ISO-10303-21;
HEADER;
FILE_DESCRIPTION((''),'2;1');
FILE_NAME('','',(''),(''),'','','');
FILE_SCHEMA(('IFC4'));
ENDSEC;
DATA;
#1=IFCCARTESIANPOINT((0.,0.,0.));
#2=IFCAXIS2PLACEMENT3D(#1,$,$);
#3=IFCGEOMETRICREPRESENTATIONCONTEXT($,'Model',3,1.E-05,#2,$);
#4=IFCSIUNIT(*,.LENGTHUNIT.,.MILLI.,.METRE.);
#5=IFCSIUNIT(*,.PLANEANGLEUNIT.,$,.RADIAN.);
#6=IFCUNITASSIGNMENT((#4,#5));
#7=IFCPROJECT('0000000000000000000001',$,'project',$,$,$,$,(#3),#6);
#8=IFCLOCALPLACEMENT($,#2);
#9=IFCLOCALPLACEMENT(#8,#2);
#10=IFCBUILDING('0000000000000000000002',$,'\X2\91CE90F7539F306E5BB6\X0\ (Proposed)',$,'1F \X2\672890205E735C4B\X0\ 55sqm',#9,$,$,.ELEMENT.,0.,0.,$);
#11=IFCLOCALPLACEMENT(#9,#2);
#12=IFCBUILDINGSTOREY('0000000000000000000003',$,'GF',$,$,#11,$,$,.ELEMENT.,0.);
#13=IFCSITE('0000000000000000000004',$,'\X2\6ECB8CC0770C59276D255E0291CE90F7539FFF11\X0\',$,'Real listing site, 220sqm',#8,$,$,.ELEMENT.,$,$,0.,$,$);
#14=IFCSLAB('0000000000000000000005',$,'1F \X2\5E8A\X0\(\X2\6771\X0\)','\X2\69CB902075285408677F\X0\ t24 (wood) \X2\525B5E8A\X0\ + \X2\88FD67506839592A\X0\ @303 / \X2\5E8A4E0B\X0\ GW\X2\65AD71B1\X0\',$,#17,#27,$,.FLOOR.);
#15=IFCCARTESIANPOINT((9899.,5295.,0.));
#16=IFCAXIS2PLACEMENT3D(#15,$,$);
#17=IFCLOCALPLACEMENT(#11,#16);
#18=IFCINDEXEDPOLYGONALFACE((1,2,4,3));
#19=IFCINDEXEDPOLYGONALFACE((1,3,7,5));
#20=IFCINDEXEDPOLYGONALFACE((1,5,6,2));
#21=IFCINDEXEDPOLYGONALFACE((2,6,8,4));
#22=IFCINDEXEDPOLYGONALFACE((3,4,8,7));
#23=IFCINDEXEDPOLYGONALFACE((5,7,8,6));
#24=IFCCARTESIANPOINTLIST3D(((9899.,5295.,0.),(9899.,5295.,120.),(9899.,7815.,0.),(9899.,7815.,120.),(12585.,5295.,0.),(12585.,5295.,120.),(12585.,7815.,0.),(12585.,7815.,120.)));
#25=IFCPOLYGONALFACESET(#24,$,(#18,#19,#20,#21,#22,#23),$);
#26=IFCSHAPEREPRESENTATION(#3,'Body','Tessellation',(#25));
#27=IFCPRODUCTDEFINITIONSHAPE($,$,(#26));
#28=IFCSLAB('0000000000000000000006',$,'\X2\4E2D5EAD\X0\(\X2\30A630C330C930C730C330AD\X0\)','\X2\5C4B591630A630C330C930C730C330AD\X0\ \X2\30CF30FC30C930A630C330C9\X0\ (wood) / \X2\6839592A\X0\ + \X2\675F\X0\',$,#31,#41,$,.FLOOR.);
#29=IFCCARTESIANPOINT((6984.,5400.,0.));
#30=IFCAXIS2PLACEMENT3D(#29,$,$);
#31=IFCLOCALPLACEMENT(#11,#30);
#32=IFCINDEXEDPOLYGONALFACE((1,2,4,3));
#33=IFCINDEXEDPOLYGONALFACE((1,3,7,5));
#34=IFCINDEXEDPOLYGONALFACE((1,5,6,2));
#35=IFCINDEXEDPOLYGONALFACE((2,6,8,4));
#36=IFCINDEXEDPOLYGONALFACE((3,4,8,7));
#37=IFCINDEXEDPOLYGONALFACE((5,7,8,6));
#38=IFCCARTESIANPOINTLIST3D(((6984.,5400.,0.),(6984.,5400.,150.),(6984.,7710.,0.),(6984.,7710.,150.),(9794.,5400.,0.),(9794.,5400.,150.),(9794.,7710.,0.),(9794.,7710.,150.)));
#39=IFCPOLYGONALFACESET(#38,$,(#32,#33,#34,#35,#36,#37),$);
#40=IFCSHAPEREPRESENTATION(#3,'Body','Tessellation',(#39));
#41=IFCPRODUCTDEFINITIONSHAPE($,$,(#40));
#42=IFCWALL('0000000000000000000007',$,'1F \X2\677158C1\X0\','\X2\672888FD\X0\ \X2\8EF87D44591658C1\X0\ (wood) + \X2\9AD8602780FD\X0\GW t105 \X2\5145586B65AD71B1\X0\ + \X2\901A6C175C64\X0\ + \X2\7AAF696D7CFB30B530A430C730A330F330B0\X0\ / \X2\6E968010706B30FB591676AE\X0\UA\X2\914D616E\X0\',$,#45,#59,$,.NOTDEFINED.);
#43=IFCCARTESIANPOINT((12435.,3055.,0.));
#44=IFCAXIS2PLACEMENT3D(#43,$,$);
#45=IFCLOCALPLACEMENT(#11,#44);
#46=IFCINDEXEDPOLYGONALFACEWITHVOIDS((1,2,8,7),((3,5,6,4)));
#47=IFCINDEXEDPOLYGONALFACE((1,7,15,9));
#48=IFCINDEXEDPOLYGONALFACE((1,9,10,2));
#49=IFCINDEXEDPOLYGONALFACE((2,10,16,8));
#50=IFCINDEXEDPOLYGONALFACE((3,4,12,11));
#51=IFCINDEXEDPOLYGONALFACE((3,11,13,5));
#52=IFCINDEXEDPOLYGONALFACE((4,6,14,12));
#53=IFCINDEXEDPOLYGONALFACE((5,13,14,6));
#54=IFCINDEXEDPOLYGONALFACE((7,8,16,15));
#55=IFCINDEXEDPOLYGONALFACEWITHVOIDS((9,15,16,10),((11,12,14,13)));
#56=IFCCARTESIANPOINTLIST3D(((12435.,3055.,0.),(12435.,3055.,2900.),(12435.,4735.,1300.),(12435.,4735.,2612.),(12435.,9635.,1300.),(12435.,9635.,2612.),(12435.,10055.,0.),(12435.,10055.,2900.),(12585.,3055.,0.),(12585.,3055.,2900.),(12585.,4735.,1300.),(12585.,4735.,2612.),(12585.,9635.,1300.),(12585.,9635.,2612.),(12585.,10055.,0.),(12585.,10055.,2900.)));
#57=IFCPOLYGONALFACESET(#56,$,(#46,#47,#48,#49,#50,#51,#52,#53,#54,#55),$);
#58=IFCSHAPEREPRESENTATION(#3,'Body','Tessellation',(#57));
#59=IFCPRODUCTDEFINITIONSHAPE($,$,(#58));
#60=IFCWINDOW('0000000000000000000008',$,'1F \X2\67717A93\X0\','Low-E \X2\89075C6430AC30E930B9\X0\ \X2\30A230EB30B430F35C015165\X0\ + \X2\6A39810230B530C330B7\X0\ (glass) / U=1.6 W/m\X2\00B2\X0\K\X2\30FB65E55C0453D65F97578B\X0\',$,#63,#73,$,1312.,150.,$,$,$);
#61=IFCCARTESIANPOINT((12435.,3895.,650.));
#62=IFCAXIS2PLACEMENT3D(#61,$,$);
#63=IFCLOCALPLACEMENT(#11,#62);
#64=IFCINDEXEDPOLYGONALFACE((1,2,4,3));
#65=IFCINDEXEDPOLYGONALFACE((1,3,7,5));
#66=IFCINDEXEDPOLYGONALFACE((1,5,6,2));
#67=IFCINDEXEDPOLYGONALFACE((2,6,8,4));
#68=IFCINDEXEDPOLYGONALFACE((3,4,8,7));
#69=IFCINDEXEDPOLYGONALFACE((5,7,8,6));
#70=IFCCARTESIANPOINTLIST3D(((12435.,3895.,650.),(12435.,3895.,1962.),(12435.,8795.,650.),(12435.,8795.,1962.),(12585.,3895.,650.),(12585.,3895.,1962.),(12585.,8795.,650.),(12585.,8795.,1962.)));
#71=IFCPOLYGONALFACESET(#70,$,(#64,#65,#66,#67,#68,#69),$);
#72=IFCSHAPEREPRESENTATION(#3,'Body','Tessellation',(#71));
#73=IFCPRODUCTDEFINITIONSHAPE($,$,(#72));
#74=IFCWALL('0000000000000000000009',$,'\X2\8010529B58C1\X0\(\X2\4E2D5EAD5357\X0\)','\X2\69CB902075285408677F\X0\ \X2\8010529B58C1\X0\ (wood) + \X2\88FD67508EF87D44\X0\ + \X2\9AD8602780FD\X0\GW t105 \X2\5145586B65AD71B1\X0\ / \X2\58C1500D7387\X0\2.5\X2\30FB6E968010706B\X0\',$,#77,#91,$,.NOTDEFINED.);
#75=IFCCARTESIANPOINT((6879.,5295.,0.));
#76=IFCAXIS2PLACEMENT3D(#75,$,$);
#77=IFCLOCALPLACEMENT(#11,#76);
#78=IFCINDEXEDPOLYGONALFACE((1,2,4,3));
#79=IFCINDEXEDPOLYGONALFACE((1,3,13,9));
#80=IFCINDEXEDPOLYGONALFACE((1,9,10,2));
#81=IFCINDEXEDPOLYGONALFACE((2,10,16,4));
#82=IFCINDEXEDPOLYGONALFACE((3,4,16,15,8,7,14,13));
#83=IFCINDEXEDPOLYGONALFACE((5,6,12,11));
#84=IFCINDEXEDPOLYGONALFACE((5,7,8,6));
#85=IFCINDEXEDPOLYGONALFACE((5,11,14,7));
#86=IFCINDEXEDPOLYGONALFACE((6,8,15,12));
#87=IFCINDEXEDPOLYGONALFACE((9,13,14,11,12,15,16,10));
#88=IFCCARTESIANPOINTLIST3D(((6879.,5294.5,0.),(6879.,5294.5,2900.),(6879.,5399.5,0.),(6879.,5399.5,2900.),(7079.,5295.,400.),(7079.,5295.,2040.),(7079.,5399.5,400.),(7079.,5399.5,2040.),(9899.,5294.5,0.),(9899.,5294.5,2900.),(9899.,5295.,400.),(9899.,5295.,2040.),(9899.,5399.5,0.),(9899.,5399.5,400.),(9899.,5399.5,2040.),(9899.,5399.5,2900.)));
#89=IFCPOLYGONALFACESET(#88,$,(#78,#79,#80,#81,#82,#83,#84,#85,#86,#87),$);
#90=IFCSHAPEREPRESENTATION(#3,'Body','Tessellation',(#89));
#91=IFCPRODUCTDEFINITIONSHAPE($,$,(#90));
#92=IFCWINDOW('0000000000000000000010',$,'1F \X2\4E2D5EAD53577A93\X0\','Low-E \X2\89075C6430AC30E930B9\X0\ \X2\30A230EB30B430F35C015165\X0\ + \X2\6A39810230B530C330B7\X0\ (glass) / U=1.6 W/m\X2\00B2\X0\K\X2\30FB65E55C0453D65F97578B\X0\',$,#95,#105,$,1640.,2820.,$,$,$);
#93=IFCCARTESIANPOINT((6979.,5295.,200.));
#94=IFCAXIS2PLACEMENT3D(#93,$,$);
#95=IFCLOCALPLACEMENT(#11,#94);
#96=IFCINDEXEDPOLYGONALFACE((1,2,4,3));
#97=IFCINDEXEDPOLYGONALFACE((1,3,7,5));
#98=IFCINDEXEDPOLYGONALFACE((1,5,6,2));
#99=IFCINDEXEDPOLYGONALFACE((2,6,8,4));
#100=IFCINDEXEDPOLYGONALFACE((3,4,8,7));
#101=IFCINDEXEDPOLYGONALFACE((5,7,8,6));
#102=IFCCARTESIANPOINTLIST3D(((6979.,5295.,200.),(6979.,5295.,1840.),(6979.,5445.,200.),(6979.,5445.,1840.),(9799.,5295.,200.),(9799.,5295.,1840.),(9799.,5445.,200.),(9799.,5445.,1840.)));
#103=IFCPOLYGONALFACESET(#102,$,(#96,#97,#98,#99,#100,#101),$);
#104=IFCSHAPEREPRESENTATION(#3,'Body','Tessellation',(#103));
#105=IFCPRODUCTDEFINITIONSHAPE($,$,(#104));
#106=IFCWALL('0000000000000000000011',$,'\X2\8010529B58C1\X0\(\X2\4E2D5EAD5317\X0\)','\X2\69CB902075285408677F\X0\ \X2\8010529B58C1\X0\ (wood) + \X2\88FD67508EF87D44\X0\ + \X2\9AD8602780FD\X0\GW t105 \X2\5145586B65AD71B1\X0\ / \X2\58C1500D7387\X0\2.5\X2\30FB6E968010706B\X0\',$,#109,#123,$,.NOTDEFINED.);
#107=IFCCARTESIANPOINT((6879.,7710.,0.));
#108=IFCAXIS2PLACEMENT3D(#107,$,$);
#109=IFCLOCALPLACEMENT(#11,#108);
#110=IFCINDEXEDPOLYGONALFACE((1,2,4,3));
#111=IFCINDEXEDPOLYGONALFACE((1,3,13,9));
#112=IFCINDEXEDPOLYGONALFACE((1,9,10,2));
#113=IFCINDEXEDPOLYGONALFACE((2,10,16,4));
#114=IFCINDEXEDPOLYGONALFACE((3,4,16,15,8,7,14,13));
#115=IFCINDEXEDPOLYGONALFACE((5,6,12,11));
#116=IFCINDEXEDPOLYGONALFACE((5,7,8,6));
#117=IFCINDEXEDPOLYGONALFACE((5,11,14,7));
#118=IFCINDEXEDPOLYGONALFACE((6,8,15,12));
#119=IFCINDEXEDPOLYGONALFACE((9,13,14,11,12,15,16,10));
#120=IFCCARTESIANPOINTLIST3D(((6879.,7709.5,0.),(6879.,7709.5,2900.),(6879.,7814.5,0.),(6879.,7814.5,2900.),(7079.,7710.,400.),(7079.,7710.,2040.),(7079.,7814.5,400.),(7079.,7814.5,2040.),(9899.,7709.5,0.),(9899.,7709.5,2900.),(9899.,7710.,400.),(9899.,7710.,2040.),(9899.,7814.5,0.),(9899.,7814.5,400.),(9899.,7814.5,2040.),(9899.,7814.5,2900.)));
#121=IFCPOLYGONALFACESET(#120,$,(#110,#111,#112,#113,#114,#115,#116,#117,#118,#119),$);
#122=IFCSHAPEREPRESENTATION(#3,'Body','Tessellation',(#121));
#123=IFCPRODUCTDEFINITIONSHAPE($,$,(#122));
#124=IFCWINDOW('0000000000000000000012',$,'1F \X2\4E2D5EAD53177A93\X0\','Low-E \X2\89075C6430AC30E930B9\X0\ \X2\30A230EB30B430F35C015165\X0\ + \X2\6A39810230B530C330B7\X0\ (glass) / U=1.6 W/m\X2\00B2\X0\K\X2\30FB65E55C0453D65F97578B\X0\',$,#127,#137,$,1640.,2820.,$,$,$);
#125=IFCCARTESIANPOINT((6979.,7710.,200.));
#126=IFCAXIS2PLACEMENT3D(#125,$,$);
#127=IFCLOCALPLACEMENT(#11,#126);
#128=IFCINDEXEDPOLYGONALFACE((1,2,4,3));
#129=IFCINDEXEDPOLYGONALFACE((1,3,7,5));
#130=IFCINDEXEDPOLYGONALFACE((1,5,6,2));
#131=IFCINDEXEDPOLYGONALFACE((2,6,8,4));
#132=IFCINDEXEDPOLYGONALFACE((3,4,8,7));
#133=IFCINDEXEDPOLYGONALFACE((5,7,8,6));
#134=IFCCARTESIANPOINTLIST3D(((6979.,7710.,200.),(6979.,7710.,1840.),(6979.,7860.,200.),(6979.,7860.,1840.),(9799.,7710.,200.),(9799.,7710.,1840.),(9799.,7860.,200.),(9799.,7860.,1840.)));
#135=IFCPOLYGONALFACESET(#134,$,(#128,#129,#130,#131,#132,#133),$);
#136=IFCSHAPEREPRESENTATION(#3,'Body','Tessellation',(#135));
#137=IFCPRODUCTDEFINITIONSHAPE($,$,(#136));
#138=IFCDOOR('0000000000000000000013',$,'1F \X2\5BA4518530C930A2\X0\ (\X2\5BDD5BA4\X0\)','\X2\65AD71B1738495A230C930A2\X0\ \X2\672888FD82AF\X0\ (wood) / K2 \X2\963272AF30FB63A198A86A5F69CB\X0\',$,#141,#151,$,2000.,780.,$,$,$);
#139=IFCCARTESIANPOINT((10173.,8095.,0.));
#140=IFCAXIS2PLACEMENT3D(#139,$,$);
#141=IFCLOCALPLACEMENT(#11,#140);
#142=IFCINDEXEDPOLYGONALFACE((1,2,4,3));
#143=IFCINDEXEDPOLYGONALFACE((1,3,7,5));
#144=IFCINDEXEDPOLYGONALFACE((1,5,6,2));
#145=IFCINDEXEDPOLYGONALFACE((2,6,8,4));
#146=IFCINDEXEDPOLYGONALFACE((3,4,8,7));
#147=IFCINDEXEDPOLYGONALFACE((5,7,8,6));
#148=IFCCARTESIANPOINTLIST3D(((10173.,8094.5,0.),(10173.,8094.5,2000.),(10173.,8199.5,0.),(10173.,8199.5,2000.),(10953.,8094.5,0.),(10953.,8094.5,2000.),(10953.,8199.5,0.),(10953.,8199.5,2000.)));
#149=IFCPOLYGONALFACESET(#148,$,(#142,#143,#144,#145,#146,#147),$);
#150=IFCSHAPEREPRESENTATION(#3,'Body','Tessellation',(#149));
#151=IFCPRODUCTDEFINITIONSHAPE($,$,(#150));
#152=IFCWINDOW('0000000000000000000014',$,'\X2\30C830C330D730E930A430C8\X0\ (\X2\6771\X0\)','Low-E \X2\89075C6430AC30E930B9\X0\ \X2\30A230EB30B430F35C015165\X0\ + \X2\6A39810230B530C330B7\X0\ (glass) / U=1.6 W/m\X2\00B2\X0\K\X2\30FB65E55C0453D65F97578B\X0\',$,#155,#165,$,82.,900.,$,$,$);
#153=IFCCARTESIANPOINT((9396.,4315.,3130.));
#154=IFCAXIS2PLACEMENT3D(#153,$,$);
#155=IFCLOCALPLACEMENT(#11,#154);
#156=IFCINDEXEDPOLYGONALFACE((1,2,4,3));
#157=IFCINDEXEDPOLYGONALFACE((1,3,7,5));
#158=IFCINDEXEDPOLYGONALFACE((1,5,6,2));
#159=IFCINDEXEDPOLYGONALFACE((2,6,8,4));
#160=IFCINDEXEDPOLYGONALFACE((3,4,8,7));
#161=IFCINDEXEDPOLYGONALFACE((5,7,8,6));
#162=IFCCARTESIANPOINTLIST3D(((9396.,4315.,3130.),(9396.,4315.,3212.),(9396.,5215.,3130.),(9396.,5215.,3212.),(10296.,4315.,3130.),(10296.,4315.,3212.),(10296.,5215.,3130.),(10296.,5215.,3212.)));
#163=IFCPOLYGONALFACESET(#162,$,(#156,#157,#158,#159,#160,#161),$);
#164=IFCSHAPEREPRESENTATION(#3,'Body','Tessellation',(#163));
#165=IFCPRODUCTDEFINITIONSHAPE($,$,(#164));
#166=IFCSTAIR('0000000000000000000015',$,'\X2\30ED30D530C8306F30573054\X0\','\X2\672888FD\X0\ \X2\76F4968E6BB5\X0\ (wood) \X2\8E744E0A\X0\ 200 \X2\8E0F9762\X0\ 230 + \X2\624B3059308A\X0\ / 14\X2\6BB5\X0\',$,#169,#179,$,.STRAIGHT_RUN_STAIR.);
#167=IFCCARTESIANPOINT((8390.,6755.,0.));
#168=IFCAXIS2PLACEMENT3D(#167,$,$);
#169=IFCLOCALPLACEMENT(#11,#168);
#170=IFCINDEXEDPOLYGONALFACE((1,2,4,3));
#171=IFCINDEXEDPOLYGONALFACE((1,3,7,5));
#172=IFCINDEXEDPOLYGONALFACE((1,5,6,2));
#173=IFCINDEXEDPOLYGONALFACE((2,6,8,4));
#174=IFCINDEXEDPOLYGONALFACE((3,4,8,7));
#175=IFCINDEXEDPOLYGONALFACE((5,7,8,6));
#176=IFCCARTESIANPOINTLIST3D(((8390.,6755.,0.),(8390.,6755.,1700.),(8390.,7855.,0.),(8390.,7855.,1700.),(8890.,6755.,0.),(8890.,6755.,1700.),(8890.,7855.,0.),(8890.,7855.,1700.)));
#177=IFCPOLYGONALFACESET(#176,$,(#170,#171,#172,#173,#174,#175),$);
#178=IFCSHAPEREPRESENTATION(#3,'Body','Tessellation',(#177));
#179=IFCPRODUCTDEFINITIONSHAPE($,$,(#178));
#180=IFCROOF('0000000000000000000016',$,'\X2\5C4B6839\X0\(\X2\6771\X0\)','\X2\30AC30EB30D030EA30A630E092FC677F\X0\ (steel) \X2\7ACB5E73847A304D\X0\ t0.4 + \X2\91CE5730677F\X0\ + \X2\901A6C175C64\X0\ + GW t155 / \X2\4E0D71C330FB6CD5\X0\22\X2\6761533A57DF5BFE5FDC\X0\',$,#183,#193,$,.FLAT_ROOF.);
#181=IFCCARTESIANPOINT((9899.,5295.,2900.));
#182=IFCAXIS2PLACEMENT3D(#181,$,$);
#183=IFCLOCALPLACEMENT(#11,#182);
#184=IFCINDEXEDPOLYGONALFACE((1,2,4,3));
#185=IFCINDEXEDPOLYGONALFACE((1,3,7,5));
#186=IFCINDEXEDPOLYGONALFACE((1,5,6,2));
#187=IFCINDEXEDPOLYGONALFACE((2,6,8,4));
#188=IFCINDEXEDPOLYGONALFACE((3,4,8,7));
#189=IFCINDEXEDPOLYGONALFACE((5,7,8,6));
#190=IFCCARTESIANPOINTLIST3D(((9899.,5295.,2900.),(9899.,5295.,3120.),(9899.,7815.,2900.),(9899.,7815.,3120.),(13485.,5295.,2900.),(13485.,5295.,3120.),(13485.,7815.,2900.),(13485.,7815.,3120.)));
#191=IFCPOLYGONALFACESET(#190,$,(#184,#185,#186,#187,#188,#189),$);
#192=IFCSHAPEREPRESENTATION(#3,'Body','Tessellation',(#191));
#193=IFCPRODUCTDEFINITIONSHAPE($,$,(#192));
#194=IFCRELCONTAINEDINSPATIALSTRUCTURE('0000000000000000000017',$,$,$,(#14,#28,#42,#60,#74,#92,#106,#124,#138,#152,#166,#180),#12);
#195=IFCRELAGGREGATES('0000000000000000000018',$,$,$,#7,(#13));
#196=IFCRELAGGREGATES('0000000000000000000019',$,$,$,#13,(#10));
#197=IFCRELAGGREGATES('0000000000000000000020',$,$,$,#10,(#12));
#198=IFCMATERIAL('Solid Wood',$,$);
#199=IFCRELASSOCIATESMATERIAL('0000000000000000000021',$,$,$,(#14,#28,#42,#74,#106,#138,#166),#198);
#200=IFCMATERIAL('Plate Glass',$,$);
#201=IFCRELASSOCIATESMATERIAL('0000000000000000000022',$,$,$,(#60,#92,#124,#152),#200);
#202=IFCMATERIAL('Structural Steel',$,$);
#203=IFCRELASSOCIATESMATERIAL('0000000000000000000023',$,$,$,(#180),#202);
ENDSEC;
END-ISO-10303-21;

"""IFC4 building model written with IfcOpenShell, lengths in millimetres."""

from ifc_helpers import new_model, si_unit, frame, frame_2d, origin, place, context, project, spatial, rectangle, extrude, material, element, fill, save


model = new_model("IFC4")

# Units and contexts
model_context = context("Model", 3, precision=1e-05, world=origin())
ifc_project = project(units=[si_unit("LENGTHUNIT", "METRE", prefix="MILLI"), si_unit("PLANEANGLEUNIT", "RADIAN")], contexts=[model_context])

# Site, building, storey
site_placement = place(None, origin())
site = spatial("IfcSite", under=ifc_project, at=site_placement, Name="滋賀県大津市野郷原１", ObjectType="Real listing site, 220sqm", CompositionType="ELEMENT", RefElevation=0.0)
building_placement = place(site_placement, origin())
building = spatial("IfcBuilding", under=site, at=building_placement, Name="野郷原の家 (Proposed)", ObjectType="1F 木造平屋 55sqm", CompositionType="ELEMENT", ElevationOfRefHeight=0.0, ElevationOfTerrain=0.0)
storey_placement = place(building_placement, origin())
storey = spatial("IfcBuildingStorey", under=building, at=storey_placement, Name="GF", CompositionType="ELEMENT", Elevation=0.0)

# Slabs
ifc_material_1 = material(Name="Solid Wood")
slab_1_placement = place(storey_placement, frame((9899.0, 5295.0, 0.0)))
element("IfcSlab", 1, at=slab_1_placement, inside=storey, material=ifc_material_1, Name="1F 床(東)", Description="構造用合板 t24 (wood) 剛床 + 製材根太 @303 / 床下 GW断熱", PredefinedType="FLOOR", context=model_context, shape_type="SweptSolid", body=[
    extrude(rectangle(XDim=2686.0, YDim=2520.0, at=frame_2d((1343.0, 1260.0))), frame((9899.0, 5295.0, 0.0)), (0.0, 0.0, 1.0), 120.0),
])
slab_2_placement = place(storey_placement, frame((6984.0, 5400.0, 0.0)))
element("IfcSlab", 2, at=slab_2_placement, inside=storey, material=ifc_material_1, Name="中庭(ウッドデッキ)", Description="屋外ウッドデッキ ハードウッド (wood) / 根太 + 束", PredefinedType="FLOOR", context=model_context, shape_type="SweptSolid", body=[
    extrude(rectangle(XDim=2810.0, YDim=2310.0, at=frame_2d((1405.0, 1155.0))), frame((6984.0, 5400.0, 0.0)), (0.0, 0.0, 1.0), 150.0),
])

# Walls, openings, windows
wall_1_placement = place(storey_placement, frame((12435.0, 3055.0, 0.0)))
wall_1 = element("IfcWall", 3, at=wall_1_placement, inside=storey, material=ifc_material_1, Name="1F 東壁", Description="木製 軸組外壁 (wood) + 高性能GW t105 充填断熱 + 通気層 + 窯業系サイディング / 準耐火・外皮UA配慮", PredefinedType="NOTDEFINED", context=model_context, shape_type="SweptSolid", body=[
    extrude(rectangle(XDim=150.0, YDim=7000.0, at=frame_2d((75.0, 3500.0))), frame((12435.0, 3055.0, 0.0)), (0.0, 0.0, 1.0), 2900.0),
])
opening_1_placement = place(storey_placement, frame((12435.0, 3895.0, 650.0)))
opening_1 = element("IfcOpeningElement", 4, at=opening_1_placement, cuts=wall_1, PredefinedType="NOTDEFINED", context=model_context, shape_type="SweptSolid", body=[
    extrude(rectangle(XDim=150.0, YDim=4900.0, at=frame_2d((75.0, 2450.0))), frame((12435.0, 3895.0, 650.0)), (0.0, 0.0, 1.0), 1312.0),
])
ifc_material_2 = material(Name="Plate Glass")
window_1_placement = place(storey_placement, frame((12435.0, 3895.0, 650.0)))
window_1 = element("IfcWindow", 5, at=window_1_placement, inside=storey, material=ifc_material_2, Name="1F 東窓", Description="Low-E 複層ガラス アルゴン封入 + 樹脂サッシ (glass) / U=1.6 W/m²K・日射取得型", OverallHeight=1312.0, OverallWidth=150.0, context=model_context, shape_type="SweptSolid", body=[
    extrude(rectangle(XDim=150.0, YDim=4900.0, at=frame_2d((75.0, 2450.0))), frame((12435.0, 3895.0, 650.0)), (0.0, 0.0, 1.0), 1312.0),
])
fill(opening_1, window_1)
wall_2_placement = place(storey_placement, frame((6879.0, 5295.0, 0.0)))
wall_2 = element("IfcWall", 6, at=wall_2_placement, inside=storey, material=ifc_material_1, Name="耐力壁(中庭南)", Description="構造用合板 耐力壁 (wood) + 製材軸組 + 高性能GW t105 充填断熱 / 壁倍率2.5・準耐火", PredefinedType="NOTDEFINED", context=model_context, shape_type="SweptSolid", body=[
    extrude(rectangle(XDim=3020.0, YDim=105.0, at=frame_2d((1510.0, 52.0))), frame((6879.0, 5295.0, 0.0)), (0.0, 0.0, 1.0), 2900.0),
])
opening_2_placement = place(storey_placement, frame((6979.0, 5295.0, 200.0)))
opening_2 = element("IfcOpeningElement", 7, at=opening_2_placement, cuts=wall_2, PredefinedType="NOTDEFINED", context=model_context, shape_type="SweptSolid", body=[
    extrude(rectangle(XDim=2820.0, YDim=150.0, at=frame_2d((1410.0, 75.0))), frame((6979.0, 5295.0, 200.0)), (0.0, 0.0, 1.0), 1640.0),
])
window_2_placement = place(storey_placement, frame((6979.0, 5295.0, 200.0)))
window_2 = element("IfcWindow", 8, at=window_2_placement, inside=storey, material=ifc_material_2, Name="1F 中庭南窓", Description="Low-E 複層ガラス アルゴン封入 + 樹脂サッシ (glass) / U=1.6 W/m²K・日射取得型", OverallHeight=1640.0, OverallWidth=2820.0, context=model_context, shape_type="SweptSolid", body=[
    extrude(rectangle(XDim=2820.0, YDim=150.0, at=frame_2d((1410.0, 75.0))), frame((6979.0, 5295.0, 200.0)), (0.0, 0.0, 1.0), 1640.0),
])
fill(opening_2, window_2)
wall_3_placement = place(storey_placement, frame((6879.0, 7710.0, 0.0)))
wall_3 = element("IfcWall", 9, at=wall_3_placement, inside=storey, material=ifc_material_1, Name="耐力壁(中庭北)", Description="構造用合板 耐力壁 (wood) + 製材軸組 + 高性能GW t105 充填断熱 / 壁倍率2.5・準耐火", PredefinedType="NOTDEFINED", context=model_context, shape_type="SweptSolid", body=[
    extrude(rectangle(XDim=3020.0, YDim=105.0, at=frame_2d((1510.0, 52.0))), frame((6879.0, 7710.0, 0.0)), (0.0, 0.0, 1.0), 2900.0),
])
opening_3_placement = place(storey_placement, frame((6979.0, 7710.0, 200.0)))
opening_3 = element("IfcOpeningElement", 10, at=opening_3_placement, cuts=wall_3, PredefinedType="NOTDEFINED", context=model_context, shape_type="SweptSolid", body=[
    extrude(rectangle(XDim=2820.0, YDim=150.0, at=frame_2d((1410.0, 75.0))), frame((6979.0, 7710.0, 200.0)), (0.0, 0.0, 1.0), 1640.0),
])
window_3_placement = place(storey_placement, frame((6979.0, 7710.0, 200.0)))
window_3 = element("IfcWindow", 11, at=window_3_placement, inside=storey, material=ifc_material_2, Name="1F 中庭北窓", Description="Low-E 複層ガラス アルゴン封入 + 樹脂サッシ (glass) / U=1.6 W/m²K・日射取得型", OverallHeight=1640.0, OverallWidth=2820.0, context=model_context, shape_type="SweptSolid", body=[
    extrude(rectangle(XDim=2820.0, YDim=150.0, at=frame_2d((1410.0, 75.0))), frame((6979.0, 7710.0, 200.0)), (0.0, 0.0, 1.0), 1640.0),
])
fill(opening_3, window_3)

# Door
door_placement = place(storey_placement, frame((10173.0, 8095.0, 0.0)))
element("IfcDoor", 12, at=door_placement, inside=storey, material=ifc_material_1, Name="1F 室内ドア (寝室)", Description="断熱玄関ドア 木製芯 (wood) / K2 防犯・採風機構", OverallHeight=2000.0, OverallWidth=780.0, context=model_context, shape_type="SweptSolid", body=[
    extrude(rectangle(XDim=780.0, YDim=105.0, at=frame_2d((390.0, 52.0))), frame((10173.0, 8095.0, 0.0)), (0.0, 0.0, 1.0), 2000.0),
])

# Window
window_4_placement = place(storey_placement, frame((9396.0, 4315.0, 3130.0)))
element("IfcWindow", 13, at=window_4_placement, inside=storey, material=ifc_material_2, Name="トップライト (東)", Description="Low-E 複層ガラス アルゴン封入 + 樹脂サッシ (glass) / U=1.6 W/m²K・日射取得型", OverallHeight=82.0, OverallWidth=900.0, context=model_context, shape_type="SweptSolid", body=[
    extrude(rectangle(XDim=900.0, YDim=900.0, at=frame_2d((450.0, 450.0))), frame((9396.0, 4315.0, 3130.0)), (0.0, 0.0, 1.0), 82.0),
])

# Stair
stair_placement = place(storey_placement, frame((8390.0, 6755.0, 0.0)))
element("IfcStair", 14, at=stair_placement, inside=storey, material=ifc_material_1, Name="ロフトはしご", Description="木製 直階段 (wood) 蹴上 200 踏面 230 + 手すり / 14段", PredefinedType="STRAIGHT_RUN_STAIR", context=model_context, shape_type="SweptSolid", body=[
    extrude(rectangle(XDim=500.0, YDim=1100.0, at=frame_2d((250.0, 550.0))), frame((8390.0, 6755.0, 0.0)), (0.0, 0.0, 1.0), 1700.0),
])

# Roof
ifc_material_3 = material(Name="Structural Steel")
roof_placement = place(storey_placement, frame((9899.0, 5295.0, 2900.0)))
element("IfcRoof", 15, at=roof_placement, inside=storey, material=ifc_material_3, Name="屋根(東)", Description="ガルバリウム鋼板 (steel) 立平葺き t0.4 + 野地板 + 通気層 + GW t155 / 不燃・法22条区域対応", PredefinedType="FLAT_ROOF", context=model_context, shape_type="SweptSolid", body=[
    extrude(rectangle(XDim=3586.0, YDim=2520.0, at=frame_2d((1793.0, 1260.0))), frame((9899.0, 5295.0, 2900.0)), (0.0, 0.0, 1.0), 220.0),
])

save(model, "model.ifc")
